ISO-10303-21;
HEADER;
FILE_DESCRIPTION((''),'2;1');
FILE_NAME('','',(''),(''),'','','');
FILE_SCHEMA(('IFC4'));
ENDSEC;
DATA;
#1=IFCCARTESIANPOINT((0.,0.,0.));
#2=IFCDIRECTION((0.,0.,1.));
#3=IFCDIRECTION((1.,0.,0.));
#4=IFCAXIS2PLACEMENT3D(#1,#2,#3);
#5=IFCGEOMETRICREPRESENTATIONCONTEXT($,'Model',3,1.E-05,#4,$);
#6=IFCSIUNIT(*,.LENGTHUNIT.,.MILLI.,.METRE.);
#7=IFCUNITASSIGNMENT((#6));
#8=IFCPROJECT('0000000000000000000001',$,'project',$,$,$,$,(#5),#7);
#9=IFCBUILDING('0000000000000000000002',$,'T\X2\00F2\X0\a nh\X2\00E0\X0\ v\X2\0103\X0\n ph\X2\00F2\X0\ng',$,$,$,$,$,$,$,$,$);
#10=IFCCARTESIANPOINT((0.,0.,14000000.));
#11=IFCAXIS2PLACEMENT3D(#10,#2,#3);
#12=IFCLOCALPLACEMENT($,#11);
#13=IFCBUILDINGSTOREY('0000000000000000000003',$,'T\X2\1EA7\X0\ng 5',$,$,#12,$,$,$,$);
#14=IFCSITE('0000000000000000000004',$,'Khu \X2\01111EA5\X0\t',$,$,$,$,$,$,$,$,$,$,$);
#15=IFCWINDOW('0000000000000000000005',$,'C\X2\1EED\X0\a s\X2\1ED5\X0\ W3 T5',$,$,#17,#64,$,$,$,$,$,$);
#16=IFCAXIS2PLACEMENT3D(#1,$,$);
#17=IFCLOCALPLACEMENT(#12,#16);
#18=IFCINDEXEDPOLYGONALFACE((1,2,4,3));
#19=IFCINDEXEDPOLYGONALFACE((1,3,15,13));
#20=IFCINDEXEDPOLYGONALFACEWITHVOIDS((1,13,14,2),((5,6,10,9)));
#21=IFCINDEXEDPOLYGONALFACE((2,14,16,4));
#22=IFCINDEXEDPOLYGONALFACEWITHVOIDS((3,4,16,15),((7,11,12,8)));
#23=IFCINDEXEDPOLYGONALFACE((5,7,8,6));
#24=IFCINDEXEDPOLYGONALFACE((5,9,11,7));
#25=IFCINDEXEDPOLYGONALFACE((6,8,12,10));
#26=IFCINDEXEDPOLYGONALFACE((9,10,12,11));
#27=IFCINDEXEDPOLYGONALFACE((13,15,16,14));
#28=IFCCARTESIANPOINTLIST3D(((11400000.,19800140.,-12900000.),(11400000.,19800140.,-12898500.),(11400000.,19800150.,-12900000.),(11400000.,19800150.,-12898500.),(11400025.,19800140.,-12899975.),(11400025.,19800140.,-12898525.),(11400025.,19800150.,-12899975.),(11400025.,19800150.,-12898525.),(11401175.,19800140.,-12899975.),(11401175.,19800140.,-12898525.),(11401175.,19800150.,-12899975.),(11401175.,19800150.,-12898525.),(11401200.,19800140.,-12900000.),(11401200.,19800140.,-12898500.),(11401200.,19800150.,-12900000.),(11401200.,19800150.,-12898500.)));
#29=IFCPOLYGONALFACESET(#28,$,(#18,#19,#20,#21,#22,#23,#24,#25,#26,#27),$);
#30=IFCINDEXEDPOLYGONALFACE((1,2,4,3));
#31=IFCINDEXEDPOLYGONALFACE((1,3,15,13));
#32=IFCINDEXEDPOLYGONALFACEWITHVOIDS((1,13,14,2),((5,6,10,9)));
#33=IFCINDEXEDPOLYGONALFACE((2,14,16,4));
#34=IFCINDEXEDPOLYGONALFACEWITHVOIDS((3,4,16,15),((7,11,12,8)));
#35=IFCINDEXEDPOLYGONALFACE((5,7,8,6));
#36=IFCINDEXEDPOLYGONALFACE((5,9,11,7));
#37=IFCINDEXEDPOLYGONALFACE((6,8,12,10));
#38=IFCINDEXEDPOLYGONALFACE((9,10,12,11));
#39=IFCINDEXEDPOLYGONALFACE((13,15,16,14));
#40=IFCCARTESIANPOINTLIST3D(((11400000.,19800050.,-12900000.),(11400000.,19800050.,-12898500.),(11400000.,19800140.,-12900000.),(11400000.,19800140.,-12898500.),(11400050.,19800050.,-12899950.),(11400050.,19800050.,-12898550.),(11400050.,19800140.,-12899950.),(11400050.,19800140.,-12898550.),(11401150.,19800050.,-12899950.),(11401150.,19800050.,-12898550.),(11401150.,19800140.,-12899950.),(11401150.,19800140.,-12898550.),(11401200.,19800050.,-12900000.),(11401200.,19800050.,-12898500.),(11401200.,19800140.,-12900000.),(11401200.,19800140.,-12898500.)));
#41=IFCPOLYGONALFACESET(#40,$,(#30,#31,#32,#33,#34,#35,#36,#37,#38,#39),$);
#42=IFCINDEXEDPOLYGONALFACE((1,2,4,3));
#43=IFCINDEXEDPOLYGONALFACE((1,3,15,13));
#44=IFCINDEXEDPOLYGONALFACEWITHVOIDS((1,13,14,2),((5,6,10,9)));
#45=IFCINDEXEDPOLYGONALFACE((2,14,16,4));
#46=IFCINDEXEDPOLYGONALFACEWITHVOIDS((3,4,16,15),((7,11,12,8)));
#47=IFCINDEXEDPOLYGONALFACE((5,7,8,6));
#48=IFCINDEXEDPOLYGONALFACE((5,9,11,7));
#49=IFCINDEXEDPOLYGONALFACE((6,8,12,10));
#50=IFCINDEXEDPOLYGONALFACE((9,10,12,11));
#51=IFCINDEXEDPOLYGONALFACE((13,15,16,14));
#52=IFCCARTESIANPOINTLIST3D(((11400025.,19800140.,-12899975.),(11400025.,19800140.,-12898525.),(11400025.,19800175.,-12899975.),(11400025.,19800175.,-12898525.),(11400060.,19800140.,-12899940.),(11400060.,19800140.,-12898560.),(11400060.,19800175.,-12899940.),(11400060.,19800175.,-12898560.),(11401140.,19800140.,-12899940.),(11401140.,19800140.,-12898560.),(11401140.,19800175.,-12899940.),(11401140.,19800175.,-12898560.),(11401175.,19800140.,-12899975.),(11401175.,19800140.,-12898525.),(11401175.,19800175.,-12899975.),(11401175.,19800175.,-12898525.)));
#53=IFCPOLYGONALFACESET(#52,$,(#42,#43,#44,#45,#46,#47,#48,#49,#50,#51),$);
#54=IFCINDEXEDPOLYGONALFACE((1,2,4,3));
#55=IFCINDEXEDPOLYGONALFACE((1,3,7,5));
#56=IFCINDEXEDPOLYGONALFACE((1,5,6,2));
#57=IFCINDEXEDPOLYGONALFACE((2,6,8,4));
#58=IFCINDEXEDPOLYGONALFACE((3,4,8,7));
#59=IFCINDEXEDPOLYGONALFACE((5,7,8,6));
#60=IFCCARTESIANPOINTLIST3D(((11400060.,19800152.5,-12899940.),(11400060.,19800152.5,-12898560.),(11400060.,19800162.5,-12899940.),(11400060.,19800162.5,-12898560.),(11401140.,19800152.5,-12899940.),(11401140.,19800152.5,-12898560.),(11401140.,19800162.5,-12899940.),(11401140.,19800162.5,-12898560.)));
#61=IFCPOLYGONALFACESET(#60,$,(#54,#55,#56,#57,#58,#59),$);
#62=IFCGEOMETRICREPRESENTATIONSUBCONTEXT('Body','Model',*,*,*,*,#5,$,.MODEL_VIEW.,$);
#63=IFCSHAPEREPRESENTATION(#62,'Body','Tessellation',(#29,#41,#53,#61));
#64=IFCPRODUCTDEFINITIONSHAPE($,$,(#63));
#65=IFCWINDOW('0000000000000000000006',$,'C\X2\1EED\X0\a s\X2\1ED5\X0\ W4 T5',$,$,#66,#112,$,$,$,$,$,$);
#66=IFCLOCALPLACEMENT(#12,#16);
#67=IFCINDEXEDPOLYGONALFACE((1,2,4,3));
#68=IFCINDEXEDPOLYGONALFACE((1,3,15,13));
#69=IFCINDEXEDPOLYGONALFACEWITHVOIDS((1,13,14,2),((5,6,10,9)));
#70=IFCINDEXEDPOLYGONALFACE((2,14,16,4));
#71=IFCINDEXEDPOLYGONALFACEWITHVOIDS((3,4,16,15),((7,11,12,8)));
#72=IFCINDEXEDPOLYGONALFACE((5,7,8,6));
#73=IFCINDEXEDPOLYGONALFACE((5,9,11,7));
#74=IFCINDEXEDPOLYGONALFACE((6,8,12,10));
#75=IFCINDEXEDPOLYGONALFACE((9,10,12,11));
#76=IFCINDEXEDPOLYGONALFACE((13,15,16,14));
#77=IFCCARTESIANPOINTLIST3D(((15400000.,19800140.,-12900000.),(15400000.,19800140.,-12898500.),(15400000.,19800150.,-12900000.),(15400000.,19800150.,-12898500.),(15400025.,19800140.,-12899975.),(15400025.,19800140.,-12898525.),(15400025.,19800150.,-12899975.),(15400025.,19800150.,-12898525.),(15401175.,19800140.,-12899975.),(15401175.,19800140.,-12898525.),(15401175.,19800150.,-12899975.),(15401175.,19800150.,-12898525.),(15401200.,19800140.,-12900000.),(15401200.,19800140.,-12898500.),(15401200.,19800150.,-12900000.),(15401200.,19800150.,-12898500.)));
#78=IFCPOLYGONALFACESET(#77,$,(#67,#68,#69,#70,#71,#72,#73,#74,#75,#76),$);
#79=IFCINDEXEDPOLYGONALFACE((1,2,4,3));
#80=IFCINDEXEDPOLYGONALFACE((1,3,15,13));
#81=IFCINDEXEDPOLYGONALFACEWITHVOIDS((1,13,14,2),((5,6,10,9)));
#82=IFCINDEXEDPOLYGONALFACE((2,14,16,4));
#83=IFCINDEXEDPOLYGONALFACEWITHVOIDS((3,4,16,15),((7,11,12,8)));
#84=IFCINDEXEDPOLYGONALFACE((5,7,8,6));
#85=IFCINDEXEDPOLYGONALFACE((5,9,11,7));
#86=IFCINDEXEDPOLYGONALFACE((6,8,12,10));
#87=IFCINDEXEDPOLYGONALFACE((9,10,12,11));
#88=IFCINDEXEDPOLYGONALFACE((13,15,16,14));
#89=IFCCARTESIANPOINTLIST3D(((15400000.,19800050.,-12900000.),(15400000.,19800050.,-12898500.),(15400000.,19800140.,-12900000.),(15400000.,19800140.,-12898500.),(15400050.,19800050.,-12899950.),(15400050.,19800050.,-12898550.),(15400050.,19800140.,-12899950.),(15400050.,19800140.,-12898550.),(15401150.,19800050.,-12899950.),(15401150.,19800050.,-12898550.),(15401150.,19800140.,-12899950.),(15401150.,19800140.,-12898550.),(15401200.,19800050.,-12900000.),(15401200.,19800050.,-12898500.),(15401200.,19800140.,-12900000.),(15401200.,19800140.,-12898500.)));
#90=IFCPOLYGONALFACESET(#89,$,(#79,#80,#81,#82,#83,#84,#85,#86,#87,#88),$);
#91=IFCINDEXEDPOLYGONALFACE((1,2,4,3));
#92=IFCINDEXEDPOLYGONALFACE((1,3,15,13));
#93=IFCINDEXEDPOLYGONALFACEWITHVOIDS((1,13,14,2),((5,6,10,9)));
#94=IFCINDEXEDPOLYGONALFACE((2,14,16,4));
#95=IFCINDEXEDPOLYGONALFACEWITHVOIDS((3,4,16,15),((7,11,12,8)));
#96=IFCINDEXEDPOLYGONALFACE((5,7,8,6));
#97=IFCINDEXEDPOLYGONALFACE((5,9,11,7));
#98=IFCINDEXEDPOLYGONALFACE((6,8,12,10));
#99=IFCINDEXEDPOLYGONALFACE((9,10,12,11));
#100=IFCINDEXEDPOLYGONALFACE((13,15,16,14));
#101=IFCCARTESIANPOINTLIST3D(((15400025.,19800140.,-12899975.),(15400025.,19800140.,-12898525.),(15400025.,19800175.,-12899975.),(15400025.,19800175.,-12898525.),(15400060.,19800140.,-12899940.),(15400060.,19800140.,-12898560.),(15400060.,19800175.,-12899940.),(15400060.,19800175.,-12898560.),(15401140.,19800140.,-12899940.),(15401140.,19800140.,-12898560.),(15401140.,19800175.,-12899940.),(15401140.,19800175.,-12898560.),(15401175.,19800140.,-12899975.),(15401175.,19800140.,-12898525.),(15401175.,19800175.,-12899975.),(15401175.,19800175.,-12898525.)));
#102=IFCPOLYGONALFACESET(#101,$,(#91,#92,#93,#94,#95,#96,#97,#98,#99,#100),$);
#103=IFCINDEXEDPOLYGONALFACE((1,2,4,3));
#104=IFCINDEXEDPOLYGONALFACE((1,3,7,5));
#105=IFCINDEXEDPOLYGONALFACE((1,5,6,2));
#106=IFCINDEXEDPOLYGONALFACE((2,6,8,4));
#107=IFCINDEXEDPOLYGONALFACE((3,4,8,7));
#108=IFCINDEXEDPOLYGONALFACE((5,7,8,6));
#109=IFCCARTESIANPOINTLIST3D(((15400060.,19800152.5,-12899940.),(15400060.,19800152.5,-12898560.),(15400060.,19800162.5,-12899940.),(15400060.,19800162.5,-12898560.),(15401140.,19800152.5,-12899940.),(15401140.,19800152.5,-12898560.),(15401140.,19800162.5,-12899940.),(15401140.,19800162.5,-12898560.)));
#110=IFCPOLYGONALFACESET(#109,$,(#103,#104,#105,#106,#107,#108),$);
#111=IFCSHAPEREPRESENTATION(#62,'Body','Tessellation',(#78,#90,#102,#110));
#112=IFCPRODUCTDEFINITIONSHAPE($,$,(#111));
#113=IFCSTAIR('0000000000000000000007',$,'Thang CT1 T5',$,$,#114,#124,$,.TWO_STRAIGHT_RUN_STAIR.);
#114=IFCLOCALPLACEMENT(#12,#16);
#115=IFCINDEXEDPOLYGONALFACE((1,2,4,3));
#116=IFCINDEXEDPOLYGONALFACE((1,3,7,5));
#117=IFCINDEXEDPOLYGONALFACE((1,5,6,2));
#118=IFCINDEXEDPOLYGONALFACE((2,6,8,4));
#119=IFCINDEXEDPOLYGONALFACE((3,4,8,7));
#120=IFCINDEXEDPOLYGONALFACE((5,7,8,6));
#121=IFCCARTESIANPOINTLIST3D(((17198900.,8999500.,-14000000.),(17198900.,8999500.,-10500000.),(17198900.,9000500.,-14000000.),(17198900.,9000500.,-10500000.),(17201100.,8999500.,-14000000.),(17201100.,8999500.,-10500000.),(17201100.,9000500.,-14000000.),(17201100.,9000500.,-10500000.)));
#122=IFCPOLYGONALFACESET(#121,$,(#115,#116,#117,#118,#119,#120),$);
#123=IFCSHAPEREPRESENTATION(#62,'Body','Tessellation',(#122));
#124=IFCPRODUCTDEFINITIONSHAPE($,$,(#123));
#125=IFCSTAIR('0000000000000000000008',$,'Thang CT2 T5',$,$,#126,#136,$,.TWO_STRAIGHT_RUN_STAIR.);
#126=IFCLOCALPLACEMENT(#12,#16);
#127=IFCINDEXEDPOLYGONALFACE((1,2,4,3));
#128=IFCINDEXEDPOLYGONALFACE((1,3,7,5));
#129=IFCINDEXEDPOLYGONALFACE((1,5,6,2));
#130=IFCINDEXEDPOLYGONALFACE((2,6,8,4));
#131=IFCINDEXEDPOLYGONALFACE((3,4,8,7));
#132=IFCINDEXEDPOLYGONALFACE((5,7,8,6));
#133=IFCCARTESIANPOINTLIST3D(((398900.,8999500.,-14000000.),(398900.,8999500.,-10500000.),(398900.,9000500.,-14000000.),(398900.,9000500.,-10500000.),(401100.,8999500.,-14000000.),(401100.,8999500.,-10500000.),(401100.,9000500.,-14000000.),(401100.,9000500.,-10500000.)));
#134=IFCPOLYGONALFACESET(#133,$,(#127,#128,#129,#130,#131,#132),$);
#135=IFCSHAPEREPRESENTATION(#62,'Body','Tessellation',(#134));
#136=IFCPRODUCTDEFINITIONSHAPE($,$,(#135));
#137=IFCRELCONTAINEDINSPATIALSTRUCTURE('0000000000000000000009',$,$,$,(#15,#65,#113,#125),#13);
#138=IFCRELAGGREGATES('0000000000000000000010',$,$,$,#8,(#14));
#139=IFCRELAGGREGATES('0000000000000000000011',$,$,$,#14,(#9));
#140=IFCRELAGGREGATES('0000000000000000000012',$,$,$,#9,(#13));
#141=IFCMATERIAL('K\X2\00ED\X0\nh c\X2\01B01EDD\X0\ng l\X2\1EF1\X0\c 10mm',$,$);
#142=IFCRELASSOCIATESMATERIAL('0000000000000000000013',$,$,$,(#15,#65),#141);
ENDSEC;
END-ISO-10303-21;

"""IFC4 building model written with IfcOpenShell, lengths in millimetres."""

from ifc_helpers import new_model, entity, si_unit, frame, origin_with_axes, place, context, subcontext, project, spatial, line, indexed_curve, outline, extrude, material, element, save


model = new_model("IFC4")

# Units and contexts
model_context = context("Model", 3, precision=1e-05, world=origin_with_axes())
body_context = subcontext(model_context, "Body", "Model", "MODEL_VIEW")
ifc_project = project(units=[si_unit("LENGTHUNIT", "METRE", prefix="MILLI")], contexts=[model_context])

# Site, building, storey
site = spatial("IfcSite", under=ifc_project, Name="Khu đất")
building = spatial("IfcBuilding", under=site, Name="Tòa nhà văn phòng")
storey_placement = place(None, frame((0.0, 0.0, 14000000.0), z_axis=(0.0, 0.0, 1.0), x_axis=(1.0, 0.0, 0.0)))
storey = spatial("IfcBuildingStorey", under=building, at=storey_placement, Name="Tầng 5")

# Windows
ifc_material_1 = material(Name="Kính cường lực 10mm")
for number, where, z_axis, x_axis, name in (
    (1, (11400000.0, 19800000.0, -12900000.0), (0.0, 0.0, 1.0), (1.0, 0.0, 0.0), "Cửa sổ W3 T5"),
    (2, (15400000.0, 19800000.0, -12900000.0), (0.0, 0.0, 1.0), (1.0, 0.0, 0.0), "Cửa sổ W4 T5"),
):
    element("IfcWindow", number, at=place(storey_placement, frame(where, z_axis=z_axis, x_axis=x_axis)), inside=storey, material=ifc_material_1, Name=name, context=body_context, shape_type="SolidModel", body=[
        extrude(outline(indexed_curve([(0.0, 0.0), (1200.0, 0.0), (1200.0, 1500.0), (0.0, 1500.0)], segments=[line(1, 2, 3, 4, 1)]), holes=[indexed_curve([(25.0, 25.0), (1175.0, 25.0), (1175.0, 1475.0), (25.0, 1475.0)], segments=[line(1, 2, 3, 4, 1)])]), frame((0.0, 140.0, 0.0), z_axis=(0.0, -1.0, 0.0), x_axis=(1.0, 0.0, 0.0)), (0.0, 0.0, -1.0), 10.0),
        extrude(outline(indexed_curve([(0.0, 0.0), (1200.0, 0.0), (1200.0, 1500.0), (0.0, 1500.0)], segments=[line(1, 2, 3, 4, 1)]), holes=[indexed_curve([(50.0, 50.0), (1150.0, 50.0), (1150.0, 1450.0), (50.0, 1450.0)], segments=[line(1, 2, 3, 4, 1)])]), frame((0.0, 50.0, 0.0), z_axis=(0.0, -1.0, 0.0), x_axis=(1.0, 0.0, 0.0)), (0.0, 0.0, -1.0), 90.0),
        extrude(outline(indexed_curve([(0.0, 0.0), (1150.0, 0.0), (1150.0, 1450.0), (0.0, 1450.0)], segments=[line(1, 2, 3, 4, 1)]), holes=[indexed_curve([(35.0, 35.0), (1115.0, 35.0), (1115.0, 1415.0), (35.0, 1415.0)], segments=[line(1, 2, 3, 4, 1)])]), frame((25.0, 140.0, 25.0), z_axis=(0.0, -1.0, 0.0), x_axis=(1.0, 0.0, 0.0)), (0.0, 0.0, -1.0), 35.0),
        extrude(outline(indexed_curve([(35.0, 35.0), (1115.0, 35.0), (1115.0, 1415.0), (35.0, 1415.0)], segments=[line(1, 2, 3, 4, 1)])), frame((25.0, 152.5, 25.0), z_axis=(0.0, -1.0, 0.0), x_axis=(1.0, 0.0, 0.0)), (0.0, 0.0, -1.0), 10.0),
    ])

# Stairs
for number, where, z_axis, x_axis, name in (
    (3, (17200000.0, 9000000.0, -14000000.0), (0.0, 0.0, 1.0), (1.0, 0.0, 0.0), "Thang CT1 T5"),
    (4, (400000.0, 9000000.0, -14000000.0), (0.0, 0.0, 1.0), (1.0, 0.0, 0.0), "Thang CT2 T5"),
):
    element("IfcStair", number, at=place(storey_placement, frame(where, z_axis=z_axis, x_axis=x_axis)), inside=storey, Name=name, PredefinedType="TWO_STRAIGHT_RUN_STAIR", context=body_context, shape_type="SweptSolid", body=[
        extrude(entity("IfcRectangleProfileDef", None, None, None, 2200.0, 1000.0), origin_with_axes(), (0.0, 0.0, 1.0), 3500000.0),
    ])

save(model, "model.ifc")
